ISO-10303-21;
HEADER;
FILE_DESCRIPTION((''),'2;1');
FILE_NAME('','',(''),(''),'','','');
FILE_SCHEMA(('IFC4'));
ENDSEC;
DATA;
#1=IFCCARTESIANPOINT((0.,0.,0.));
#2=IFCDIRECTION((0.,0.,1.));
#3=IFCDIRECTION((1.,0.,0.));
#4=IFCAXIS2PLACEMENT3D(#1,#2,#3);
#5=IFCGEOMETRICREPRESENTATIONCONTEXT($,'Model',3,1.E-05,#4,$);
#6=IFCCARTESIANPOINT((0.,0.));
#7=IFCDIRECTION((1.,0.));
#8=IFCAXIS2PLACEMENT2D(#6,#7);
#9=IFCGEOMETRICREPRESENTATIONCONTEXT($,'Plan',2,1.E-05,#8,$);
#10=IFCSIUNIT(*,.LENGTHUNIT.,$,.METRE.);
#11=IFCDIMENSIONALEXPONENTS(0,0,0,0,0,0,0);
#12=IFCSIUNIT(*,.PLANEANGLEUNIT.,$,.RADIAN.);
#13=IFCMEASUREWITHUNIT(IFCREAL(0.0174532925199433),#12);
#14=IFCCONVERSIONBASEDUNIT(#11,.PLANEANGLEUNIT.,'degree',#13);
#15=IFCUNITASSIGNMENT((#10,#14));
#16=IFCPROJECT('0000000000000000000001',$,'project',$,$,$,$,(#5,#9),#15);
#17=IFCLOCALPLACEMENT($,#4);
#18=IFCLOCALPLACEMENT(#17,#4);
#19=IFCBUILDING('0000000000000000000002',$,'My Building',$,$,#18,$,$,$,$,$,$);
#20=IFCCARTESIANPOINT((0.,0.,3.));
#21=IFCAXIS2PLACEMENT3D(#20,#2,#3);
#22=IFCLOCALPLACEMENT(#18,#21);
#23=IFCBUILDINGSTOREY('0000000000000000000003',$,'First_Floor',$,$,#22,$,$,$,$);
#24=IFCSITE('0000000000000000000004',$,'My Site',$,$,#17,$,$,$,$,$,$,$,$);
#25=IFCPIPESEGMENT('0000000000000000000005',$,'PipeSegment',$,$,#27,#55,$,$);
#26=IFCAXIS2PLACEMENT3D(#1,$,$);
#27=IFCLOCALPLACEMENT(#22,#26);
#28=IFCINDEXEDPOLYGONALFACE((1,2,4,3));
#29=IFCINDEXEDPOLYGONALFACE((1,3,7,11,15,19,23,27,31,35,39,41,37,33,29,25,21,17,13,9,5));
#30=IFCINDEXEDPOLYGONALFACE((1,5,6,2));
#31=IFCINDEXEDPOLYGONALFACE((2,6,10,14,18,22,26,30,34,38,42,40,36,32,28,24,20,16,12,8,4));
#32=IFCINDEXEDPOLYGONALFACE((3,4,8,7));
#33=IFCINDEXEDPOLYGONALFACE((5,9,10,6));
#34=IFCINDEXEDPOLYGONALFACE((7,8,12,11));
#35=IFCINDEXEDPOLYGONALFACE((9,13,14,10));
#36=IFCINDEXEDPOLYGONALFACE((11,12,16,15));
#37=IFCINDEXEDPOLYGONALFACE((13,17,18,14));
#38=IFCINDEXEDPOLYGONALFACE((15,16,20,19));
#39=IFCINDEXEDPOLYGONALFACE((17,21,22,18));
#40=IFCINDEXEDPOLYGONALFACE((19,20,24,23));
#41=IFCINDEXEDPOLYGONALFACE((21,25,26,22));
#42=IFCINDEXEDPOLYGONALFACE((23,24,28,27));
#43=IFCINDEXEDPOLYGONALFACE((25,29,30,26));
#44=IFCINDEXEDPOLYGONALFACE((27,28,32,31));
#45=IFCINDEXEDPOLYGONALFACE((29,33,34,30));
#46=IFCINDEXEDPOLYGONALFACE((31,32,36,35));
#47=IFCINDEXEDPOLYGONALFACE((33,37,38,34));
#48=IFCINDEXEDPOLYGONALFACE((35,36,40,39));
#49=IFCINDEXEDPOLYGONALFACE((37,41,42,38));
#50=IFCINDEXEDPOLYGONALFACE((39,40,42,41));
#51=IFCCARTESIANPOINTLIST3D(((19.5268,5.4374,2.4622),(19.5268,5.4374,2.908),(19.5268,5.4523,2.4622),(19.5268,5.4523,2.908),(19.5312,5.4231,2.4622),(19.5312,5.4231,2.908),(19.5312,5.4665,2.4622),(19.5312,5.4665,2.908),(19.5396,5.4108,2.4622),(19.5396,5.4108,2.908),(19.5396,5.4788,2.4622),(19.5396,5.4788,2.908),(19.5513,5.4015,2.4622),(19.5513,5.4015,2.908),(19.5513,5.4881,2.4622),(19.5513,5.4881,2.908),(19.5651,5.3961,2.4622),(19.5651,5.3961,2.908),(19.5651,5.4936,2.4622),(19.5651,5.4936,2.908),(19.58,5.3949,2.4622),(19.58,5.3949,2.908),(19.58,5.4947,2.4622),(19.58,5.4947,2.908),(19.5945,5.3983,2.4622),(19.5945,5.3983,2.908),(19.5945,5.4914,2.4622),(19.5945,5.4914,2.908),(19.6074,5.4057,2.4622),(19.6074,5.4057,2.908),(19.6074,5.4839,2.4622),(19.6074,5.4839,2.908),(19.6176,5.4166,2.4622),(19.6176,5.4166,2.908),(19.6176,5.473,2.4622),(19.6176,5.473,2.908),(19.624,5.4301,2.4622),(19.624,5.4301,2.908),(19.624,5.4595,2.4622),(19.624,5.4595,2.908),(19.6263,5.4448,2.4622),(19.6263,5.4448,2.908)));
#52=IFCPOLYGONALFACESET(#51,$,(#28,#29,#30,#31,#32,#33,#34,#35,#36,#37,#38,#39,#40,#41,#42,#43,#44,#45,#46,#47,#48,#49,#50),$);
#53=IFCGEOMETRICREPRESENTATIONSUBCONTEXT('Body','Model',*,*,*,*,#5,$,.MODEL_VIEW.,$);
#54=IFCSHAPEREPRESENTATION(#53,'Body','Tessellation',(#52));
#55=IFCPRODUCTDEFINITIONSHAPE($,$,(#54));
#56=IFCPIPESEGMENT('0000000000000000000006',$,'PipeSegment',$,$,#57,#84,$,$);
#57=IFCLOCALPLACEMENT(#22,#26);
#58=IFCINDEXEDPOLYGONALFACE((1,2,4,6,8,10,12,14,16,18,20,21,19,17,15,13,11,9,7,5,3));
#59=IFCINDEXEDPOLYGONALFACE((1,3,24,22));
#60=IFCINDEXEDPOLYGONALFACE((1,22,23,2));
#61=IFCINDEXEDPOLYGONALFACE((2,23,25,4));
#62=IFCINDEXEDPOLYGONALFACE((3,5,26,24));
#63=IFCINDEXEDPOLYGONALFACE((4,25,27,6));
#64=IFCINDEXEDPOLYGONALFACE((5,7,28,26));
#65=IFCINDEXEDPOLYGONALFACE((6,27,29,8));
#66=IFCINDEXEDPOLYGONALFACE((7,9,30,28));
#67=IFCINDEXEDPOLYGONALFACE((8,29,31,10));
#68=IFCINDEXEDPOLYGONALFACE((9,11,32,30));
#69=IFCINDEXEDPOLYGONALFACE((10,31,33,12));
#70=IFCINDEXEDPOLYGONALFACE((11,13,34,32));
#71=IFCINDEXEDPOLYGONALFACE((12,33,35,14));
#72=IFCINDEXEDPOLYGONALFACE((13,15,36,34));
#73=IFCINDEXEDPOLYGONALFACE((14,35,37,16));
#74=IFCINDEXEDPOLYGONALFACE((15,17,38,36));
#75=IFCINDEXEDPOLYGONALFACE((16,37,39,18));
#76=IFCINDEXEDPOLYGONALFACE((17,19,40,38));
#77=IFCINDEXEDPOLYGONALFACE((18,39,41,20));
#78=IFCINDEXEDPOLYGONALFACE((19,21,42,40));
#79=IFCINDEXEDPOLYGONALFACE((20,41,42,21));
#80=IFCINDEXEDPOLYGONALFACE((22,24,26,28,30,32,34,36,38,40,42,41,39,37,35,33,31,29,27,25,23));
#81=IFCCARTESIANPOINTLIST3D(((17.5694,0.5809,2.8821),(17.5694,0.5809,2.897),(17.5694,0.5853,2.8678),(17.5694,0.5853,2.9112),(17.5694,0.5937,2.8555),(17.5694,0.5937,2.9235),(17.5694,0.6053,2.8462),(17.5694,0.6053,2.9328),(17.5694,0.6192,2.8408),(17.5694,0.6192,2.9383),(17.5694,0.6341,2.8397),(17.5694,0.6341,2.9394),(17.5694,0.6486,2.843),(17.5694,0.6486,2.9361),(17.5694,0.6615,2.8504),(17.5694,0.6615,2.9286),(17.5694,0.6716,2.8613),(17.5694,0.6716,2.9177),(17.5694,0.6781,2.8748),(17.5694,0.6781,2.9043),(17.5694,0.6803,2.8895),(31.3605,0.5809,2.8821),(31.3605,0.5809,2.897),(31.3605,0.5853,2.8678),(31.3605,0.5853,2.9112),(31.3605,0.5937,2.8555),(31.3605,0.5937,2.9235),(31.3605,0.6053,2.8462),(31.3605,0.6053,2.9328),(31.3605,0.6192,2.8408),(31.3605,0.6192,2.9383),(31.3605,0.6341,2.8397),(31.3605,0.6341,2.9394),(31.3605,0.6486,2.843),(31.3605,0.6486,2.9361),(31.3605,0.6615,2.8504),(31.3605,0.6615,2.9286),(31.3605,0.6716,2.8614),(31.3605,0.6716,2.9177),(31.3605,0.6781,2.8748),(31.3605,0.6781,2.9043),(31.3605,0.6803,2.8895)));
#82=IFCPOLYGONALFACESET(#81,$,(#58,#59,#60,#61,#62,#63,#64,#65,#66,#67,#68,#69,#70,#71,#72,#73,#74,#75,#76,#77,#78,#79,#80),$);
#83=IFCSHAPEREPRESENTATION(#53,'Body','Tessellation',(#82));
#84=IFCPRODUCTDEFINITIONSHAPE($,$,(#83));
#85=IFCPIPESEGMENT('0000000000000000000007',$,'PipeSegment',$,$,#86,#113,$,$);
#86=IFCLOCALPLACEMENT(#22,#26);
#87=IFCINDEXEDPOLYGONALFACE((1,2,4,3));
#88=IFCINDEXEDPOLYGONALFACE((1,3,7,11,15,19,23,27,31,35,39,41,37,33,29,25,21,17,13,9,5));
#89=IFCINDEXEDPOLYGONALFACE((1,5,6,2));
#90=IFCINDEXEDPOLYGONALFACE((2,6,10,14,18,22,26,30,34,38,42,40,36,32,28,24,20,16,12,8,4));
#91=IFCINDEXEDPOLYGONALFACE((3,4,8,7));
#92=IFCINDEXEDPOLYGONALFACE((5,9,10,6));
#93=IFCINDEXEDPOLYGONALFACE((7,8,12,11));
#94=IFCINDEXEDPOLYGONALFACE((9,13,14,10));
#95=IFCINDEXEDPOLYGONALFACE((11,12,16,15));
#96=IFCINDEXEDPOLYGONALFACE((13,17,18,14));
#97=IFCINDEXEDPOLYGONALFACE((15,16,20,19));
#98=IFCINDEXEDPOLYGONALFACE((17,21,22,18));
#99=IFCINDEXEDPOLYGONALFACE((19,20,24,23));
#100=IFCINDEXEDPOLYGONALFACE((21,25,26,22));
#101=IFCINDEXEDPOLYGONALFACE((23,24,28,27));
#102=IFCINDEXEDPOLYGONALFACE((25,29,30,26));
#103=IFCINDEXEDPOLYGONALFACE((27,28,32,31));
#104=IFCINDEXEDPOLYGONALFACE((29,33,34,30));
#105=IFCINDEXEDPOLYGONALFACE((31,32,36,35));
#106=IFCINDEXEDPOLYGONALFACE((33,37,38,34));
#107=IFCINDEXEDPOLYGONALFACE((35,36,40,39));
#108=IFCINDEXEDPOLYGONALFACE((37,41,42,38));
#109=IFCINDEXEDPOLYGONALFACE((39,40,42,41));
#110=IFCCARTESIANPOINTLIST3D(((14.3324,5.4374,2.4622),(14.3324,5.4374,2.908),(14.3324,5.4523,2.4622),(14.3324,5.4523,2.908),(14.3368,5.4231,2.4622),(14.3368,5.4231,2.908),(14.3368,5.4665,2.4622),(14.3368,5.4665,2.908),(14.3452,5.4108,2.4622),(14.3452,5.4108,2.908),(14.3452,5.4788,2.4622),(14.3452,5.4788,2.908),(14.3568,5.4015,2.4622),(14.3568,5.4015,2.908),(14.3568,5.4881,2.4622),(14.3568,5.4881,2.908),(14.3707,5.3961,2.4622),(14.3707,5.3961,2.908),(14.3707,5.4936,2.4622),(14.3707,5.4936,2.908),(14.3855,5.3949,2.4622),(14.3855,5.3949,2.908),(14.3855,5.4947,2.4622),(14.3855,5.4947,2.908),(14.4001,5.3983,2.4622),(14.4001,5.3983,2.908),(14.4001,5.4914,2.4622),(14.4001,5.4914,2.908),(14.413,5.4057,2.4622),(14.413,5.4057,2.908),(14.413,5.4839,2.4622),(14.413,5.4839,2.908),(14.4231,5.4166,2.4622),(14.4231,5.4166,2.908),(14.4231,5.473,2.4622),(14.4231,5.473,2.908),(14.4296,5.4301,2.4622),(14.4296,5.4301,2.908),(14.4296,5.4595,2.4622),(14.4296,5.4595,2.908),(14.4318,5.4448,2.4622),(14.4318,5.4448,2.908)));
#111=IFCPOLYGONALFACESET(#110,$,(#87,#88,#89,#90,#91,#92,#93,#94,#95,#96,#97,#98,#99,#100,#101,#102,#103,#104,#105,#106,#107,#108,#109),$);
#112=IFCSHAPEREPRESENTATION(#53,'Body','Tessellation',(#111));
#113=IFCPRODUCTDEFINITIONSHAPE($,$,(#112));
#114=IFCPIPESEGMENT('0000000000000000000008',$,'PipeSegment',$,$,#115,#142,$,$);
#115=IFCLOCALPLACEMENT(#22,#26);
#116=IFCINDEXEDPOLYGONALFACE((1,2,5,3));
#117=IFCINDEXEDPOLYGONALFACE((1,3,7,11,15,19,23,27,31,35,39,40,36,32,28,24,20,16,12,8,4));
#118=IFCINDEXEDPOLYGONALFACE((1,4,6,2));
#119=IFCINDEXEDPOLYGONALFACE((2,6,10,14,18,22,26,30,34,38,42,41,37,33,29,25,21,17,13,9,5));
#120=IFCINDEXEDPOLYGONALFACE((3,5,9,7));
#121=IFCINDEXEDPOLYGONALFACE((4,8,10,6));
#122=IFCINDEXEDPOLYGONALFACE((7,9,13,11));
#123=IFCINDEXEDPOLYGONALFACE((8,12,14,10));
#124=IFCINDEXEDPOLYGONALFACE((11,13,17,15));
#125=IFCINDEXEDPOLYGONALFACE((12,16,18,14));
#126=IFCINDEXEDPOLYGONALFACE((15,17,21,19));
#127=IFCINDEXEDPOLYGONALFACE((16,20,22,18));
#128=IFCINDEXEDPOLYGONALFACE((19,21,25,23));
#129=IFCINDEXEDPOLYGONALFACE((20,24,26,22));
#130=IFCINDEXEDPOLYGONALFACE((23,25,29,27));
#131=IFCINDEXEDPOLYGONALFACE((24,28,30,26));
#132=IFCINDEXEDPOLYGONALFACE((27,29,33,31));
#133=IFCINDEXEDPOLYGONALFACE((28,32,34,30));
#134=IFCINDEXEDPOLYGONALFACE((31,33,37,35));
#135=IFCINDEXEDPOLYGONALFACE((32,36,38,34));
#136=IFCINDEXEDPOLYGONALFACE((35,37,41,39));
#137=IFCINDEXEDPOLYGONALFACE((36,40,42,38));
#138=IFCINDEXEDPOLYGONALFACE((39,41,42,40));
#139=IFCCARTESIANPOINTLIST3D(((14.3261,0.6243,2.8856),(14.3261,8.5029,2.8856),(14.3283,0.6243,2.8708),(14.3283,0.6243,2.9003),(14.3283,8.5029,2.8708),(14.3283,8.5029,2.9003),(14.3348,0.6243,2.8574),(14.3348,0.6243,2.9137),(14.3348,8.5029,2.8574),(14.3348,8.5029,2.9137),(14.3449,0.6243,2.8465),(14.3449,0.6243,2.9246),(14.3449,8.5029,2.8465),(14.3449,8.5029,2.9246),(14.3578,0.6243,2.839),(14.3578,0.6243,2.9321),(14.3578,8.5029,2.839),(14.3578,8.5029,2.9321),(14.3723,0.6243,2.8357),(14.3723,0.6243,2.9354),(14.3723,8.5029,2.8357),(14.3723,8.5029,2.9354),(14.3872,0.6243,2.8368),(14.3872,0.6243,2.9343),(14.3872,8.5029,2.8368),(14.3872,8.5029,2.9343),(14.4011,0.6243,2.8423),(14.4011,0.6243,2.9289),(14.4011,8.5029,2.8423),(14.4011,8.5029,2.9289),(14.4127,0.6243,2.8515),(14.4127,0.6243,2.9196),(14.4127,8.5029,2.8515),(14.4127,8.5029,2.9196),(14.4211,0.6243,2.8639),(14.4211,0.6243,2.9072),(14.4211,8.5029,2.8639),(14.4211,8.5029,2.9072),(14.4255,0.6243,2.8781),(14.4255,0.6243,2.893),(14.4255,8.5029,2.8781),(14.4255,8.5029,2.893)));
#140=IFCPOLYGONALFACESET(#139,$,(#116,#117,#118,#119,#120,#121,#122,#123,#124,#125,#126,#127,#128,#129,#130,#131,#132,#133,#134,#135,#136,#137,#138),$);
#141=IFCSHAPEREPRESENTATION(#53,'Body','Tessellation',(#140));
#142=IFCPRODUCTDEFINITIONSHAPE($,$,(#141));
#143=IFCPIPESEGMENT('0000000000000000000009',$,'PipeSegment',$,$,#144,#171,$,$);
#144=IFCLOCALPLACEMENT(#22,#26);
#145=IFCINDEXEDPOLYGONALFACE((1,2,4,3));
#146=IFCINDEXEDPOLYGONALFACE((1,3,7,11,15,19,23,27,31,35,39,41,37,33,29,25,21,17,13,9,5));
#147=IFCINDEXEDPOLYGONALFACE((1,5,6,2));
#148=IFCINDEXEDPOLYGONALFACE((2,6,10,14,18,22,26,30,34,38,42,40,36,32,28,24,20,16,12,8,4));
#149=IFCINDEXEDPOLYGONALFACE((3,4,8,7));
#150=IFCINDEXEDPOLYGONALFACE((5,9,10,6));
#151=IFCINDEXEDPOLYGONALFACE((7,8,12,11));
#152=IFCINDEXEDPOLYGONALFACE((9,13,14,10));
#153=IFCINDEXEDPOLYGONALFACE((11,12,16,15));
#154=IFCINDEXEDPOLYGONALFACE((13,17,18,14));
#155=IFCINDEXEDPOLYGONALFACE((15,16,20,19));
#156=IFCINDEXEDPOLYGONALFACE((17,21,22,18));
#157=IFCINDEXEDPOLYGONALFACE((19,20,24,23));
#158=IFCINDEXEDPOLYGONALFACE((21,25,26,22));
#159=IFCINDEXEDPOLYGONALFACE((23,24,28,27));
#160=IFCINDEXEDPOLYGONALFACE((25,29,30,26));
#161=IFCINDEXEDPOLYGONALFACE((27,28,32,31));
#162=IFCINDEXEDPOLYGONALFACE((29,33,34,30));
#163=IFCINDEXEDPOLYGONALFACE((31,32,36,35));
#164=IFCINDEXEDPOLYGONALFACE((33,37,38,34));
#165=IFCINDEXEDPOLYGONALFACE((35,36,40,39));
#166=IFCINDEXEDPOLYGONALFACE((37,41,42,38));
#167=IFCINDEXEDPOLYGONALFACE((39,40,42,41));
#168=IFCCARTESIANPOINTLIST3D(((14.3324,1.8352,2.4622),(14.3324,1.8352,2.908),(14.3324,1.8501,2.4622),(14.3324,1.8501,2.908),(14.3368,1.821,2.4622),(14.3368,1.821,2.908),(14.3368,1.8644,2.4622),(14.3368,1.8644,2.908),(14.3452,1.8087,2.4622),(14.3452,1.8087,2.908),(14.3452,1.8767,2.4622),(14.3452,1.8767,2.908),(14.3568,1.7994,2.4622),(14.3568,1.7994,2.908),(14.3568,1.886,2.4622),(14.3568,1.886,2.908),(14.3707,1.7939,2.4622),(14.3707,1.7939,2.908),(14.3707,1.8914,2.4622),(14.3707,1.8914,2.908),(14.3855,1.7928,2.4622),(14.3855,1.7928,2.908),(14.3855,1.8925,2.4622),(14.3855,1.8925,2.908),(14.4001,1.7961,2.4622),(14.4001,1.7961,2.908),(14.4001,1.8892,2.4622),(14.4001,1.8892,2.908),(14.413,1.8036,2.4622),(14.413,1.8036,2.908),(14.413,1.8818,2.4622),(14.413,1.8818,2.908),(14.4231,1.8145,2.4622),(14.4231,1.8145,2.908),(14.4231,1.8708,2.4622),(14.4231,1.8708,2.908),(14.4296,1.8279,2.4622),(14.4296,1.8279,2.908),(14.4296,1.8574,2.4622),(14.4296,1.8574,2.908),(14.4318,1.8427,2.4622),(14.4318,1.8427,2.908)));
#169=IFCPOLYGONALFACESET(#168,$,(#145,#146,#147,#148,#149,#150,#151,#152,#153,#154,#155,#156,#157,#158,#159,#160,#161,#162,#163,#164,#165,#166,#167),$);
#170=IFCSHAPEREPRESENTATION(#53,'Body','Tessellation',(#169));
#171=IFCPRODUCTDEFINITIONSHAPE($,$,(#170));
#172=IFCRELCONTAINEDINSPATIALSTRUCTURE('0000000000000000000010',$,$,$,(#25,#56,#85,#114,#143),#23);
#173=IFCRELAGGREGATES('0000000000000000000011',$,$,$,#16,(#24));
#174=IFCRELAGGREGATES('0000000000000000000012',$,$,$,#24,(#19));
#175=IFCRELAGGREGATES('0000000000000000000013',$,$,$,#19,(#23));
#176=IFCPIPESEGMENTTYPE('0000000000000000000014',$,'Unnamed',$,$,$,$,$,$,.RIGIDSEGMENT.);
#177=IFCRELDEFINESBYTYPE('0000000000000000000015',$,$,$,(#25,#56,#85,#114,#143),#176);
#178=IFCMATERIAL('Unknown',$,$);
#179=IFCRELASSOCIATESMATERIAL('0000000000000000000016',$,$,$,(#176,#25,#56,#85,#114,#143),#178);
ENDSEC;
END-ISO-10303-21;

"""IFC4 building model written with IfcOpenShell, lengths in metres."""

from ifc_helpers import new_model, entity, si_unit, converted_unit, frame, origin_with_axes, origin_2d_with_axis, place, context, subcontext, project, spatial, circle, extrude, material, material_profile, profile_set, profile_usage, type_object, element, save


model = new_model("IFC4")

# Units and contexts
model_context = context("Model", 3, precision=1e-05, world=origin_with_axes())
plan_context = context("Plan", 2, precision=1e-05, world=origin_2d_with_axis())
body_context = subcontext(model_context, "Body", "Model", "MODEL_VIEW")
ifc_project = project(units=[si_unit("LENGTHUNIT", "METRE"), converted_unit("PLANEANGLEUNIT", "degree", entity("IfcReal", 0.0174532925199433), si_unit("PLANEANGLEUNIT", "RADIAN"), dimensions=[0, 0, 0, 0, 0, 0, 0])], contexts=[model_context, plan_context])

# Site, building, storey
site_placement = place(None, origin_with_axes())
site = spatial("IfcSite", under=ifc_project, at=site_placement, Name="My Site")
building_placement = place(site_placement, origin_with_axes())
building = spatial("IfcBuilding", under=site, at=building_placement, Name="My Building")
storey_placement = place(building_placement, frame((0.0, 0.0, 3.0), z_axis=(0.0, 0.0, 1.0), x_axis=(1.0, 0.0, 0.0)))
storey = spatial("IfcBuildingStorey", under=building, at=storey_placement, Name="First_Floor")

# Shared definitions
ifc_material = material(Name="Unknown")

# Pipe segments
ifc_material_profile_1 = material_profile(ifc_material, circle(Radius=0.05))
ifc_profile_set_1 = profile_set([ifc_material_profile_1])
pipe_segment_type = type_object("IfcPipeSegmentType", Name="Unnamed", PredefinedType="RIGIDSEGMENT", material=ifc_profile_set_1)
ifc_profile_usage_1 = profile_usage(ifc_profile_set_1, cardinal=5)
pipe_segment_1_placement = place(storey_placement, frame((19.5763, 5.4448, 2.908), z_axis=(0.0, 0.0, -1.0), x_axis=(1.0, 0.0, 0.0)))
element("IfcPipeSegment", 1, at=pipe_segment_1_placement, inside=storey, type_object=pipe_segment_type, material=ifc_profile_usage_1, Name="PipeSegment", context=body_context, shape_type="SweptSolid", body=[
    extrude(circle(Radius=0.05), origin_with_axes(), (0.0, 0.0, 1.0), 0.4458),
])
ifc_profile_usage_2 = profile_usage(ifc_profile_set_1, cardinal=1)
pipe_segment_2_placement = place(storey_placement, frame((17.5694, 0.6803, 2.8395), z_axis=(1.0, 0.0, 0.0), x_axis=(0.0, 1.0, 0.0)))
element("IfcPipeSegment", 2, at=pipe_segment_2_placement, inside=storey, type_object=pipe_segment_type, material=ifc_profile_usage_2, Name="PipeSegment", context=body_context, shape_type="SweptSolid", body=[
    extrude(circle(Radius=0.05), frame((-0.05, 0.05, 0.0), z_axis=(0.0, 0.0, 1.0), x_axis=(1.0, 0.0, 0.0)), (0.0, 0.0, 1.0), 13.7911),
])
ifc_profile_usage_3 = profile_usage(ifc_profile_set_1, cardinal=5)
pipe_segment_3_placement = place(storey_placement, frame((14.3818, 5.4448, 2.908), z_axis=(0.0, 0.0, -1.0), x_axis=(1.0, 0.0, 0.0)))
element("IfcPipeSegment", 3, at=pipe_segment_3_placement, inside=storey, type_object=pipe_segment_type, material=ifc_profile_usage_3, Name="PipeSegment", context=body_context, shape_type="SweptSolid", body=[
    extrude(circle(Radius=0.05), origin_with_axes(), (0.0, 0.0, 1.0), 0.4458),
])
ifc_profile_usage_4 = profile_usage(ifc_profile_set_1, cardinal=5)
pipe_segment_4_placement = place(storey_placement, frame((14.3761, 0.6243, 2.8856), z_axis=(0.0, 1.0, 0.0), x_axis=(-1.0, 0.0, 0.0)))
element("IfcPipeSegment", 4, at=pipe_segment_4_placement, inside=storey, type_object=pipe_segment_type, material=ifc_profile_usage_4, Name="PipeSegment", context=body_context, shape_type="SweptSolid", body=[
    extrude(circle(Radius=0.05), origin_with_axes(), (0.0, 0.0, 1.0), 7.8786),
])
ifc_profile_usage_5 = profile_usage(ifc_profile_set_1, cardinal=5)
pipe_segment_5_placement = place(storey_placement, frame((14.3818, 1.8427, 2.908), z_axis=(0.0, 0.0, -1.0), x_axis=(1.0, 0.0, 0.0)))
element("IfcPipeSegment", 5, at=pipe_segment_5_placement, inside=storey, type_object=pipe_segment_type, material=ifc_profile_usage_5, Name="PipeSegment", context=body_context, shape_type="SweptSolid", body=[
    extrude(circle(Radius=0.05), origin_with_axes(), (0.0, 0.0, 1.0), 0.4458),
])

save(model, "model.ifc")
